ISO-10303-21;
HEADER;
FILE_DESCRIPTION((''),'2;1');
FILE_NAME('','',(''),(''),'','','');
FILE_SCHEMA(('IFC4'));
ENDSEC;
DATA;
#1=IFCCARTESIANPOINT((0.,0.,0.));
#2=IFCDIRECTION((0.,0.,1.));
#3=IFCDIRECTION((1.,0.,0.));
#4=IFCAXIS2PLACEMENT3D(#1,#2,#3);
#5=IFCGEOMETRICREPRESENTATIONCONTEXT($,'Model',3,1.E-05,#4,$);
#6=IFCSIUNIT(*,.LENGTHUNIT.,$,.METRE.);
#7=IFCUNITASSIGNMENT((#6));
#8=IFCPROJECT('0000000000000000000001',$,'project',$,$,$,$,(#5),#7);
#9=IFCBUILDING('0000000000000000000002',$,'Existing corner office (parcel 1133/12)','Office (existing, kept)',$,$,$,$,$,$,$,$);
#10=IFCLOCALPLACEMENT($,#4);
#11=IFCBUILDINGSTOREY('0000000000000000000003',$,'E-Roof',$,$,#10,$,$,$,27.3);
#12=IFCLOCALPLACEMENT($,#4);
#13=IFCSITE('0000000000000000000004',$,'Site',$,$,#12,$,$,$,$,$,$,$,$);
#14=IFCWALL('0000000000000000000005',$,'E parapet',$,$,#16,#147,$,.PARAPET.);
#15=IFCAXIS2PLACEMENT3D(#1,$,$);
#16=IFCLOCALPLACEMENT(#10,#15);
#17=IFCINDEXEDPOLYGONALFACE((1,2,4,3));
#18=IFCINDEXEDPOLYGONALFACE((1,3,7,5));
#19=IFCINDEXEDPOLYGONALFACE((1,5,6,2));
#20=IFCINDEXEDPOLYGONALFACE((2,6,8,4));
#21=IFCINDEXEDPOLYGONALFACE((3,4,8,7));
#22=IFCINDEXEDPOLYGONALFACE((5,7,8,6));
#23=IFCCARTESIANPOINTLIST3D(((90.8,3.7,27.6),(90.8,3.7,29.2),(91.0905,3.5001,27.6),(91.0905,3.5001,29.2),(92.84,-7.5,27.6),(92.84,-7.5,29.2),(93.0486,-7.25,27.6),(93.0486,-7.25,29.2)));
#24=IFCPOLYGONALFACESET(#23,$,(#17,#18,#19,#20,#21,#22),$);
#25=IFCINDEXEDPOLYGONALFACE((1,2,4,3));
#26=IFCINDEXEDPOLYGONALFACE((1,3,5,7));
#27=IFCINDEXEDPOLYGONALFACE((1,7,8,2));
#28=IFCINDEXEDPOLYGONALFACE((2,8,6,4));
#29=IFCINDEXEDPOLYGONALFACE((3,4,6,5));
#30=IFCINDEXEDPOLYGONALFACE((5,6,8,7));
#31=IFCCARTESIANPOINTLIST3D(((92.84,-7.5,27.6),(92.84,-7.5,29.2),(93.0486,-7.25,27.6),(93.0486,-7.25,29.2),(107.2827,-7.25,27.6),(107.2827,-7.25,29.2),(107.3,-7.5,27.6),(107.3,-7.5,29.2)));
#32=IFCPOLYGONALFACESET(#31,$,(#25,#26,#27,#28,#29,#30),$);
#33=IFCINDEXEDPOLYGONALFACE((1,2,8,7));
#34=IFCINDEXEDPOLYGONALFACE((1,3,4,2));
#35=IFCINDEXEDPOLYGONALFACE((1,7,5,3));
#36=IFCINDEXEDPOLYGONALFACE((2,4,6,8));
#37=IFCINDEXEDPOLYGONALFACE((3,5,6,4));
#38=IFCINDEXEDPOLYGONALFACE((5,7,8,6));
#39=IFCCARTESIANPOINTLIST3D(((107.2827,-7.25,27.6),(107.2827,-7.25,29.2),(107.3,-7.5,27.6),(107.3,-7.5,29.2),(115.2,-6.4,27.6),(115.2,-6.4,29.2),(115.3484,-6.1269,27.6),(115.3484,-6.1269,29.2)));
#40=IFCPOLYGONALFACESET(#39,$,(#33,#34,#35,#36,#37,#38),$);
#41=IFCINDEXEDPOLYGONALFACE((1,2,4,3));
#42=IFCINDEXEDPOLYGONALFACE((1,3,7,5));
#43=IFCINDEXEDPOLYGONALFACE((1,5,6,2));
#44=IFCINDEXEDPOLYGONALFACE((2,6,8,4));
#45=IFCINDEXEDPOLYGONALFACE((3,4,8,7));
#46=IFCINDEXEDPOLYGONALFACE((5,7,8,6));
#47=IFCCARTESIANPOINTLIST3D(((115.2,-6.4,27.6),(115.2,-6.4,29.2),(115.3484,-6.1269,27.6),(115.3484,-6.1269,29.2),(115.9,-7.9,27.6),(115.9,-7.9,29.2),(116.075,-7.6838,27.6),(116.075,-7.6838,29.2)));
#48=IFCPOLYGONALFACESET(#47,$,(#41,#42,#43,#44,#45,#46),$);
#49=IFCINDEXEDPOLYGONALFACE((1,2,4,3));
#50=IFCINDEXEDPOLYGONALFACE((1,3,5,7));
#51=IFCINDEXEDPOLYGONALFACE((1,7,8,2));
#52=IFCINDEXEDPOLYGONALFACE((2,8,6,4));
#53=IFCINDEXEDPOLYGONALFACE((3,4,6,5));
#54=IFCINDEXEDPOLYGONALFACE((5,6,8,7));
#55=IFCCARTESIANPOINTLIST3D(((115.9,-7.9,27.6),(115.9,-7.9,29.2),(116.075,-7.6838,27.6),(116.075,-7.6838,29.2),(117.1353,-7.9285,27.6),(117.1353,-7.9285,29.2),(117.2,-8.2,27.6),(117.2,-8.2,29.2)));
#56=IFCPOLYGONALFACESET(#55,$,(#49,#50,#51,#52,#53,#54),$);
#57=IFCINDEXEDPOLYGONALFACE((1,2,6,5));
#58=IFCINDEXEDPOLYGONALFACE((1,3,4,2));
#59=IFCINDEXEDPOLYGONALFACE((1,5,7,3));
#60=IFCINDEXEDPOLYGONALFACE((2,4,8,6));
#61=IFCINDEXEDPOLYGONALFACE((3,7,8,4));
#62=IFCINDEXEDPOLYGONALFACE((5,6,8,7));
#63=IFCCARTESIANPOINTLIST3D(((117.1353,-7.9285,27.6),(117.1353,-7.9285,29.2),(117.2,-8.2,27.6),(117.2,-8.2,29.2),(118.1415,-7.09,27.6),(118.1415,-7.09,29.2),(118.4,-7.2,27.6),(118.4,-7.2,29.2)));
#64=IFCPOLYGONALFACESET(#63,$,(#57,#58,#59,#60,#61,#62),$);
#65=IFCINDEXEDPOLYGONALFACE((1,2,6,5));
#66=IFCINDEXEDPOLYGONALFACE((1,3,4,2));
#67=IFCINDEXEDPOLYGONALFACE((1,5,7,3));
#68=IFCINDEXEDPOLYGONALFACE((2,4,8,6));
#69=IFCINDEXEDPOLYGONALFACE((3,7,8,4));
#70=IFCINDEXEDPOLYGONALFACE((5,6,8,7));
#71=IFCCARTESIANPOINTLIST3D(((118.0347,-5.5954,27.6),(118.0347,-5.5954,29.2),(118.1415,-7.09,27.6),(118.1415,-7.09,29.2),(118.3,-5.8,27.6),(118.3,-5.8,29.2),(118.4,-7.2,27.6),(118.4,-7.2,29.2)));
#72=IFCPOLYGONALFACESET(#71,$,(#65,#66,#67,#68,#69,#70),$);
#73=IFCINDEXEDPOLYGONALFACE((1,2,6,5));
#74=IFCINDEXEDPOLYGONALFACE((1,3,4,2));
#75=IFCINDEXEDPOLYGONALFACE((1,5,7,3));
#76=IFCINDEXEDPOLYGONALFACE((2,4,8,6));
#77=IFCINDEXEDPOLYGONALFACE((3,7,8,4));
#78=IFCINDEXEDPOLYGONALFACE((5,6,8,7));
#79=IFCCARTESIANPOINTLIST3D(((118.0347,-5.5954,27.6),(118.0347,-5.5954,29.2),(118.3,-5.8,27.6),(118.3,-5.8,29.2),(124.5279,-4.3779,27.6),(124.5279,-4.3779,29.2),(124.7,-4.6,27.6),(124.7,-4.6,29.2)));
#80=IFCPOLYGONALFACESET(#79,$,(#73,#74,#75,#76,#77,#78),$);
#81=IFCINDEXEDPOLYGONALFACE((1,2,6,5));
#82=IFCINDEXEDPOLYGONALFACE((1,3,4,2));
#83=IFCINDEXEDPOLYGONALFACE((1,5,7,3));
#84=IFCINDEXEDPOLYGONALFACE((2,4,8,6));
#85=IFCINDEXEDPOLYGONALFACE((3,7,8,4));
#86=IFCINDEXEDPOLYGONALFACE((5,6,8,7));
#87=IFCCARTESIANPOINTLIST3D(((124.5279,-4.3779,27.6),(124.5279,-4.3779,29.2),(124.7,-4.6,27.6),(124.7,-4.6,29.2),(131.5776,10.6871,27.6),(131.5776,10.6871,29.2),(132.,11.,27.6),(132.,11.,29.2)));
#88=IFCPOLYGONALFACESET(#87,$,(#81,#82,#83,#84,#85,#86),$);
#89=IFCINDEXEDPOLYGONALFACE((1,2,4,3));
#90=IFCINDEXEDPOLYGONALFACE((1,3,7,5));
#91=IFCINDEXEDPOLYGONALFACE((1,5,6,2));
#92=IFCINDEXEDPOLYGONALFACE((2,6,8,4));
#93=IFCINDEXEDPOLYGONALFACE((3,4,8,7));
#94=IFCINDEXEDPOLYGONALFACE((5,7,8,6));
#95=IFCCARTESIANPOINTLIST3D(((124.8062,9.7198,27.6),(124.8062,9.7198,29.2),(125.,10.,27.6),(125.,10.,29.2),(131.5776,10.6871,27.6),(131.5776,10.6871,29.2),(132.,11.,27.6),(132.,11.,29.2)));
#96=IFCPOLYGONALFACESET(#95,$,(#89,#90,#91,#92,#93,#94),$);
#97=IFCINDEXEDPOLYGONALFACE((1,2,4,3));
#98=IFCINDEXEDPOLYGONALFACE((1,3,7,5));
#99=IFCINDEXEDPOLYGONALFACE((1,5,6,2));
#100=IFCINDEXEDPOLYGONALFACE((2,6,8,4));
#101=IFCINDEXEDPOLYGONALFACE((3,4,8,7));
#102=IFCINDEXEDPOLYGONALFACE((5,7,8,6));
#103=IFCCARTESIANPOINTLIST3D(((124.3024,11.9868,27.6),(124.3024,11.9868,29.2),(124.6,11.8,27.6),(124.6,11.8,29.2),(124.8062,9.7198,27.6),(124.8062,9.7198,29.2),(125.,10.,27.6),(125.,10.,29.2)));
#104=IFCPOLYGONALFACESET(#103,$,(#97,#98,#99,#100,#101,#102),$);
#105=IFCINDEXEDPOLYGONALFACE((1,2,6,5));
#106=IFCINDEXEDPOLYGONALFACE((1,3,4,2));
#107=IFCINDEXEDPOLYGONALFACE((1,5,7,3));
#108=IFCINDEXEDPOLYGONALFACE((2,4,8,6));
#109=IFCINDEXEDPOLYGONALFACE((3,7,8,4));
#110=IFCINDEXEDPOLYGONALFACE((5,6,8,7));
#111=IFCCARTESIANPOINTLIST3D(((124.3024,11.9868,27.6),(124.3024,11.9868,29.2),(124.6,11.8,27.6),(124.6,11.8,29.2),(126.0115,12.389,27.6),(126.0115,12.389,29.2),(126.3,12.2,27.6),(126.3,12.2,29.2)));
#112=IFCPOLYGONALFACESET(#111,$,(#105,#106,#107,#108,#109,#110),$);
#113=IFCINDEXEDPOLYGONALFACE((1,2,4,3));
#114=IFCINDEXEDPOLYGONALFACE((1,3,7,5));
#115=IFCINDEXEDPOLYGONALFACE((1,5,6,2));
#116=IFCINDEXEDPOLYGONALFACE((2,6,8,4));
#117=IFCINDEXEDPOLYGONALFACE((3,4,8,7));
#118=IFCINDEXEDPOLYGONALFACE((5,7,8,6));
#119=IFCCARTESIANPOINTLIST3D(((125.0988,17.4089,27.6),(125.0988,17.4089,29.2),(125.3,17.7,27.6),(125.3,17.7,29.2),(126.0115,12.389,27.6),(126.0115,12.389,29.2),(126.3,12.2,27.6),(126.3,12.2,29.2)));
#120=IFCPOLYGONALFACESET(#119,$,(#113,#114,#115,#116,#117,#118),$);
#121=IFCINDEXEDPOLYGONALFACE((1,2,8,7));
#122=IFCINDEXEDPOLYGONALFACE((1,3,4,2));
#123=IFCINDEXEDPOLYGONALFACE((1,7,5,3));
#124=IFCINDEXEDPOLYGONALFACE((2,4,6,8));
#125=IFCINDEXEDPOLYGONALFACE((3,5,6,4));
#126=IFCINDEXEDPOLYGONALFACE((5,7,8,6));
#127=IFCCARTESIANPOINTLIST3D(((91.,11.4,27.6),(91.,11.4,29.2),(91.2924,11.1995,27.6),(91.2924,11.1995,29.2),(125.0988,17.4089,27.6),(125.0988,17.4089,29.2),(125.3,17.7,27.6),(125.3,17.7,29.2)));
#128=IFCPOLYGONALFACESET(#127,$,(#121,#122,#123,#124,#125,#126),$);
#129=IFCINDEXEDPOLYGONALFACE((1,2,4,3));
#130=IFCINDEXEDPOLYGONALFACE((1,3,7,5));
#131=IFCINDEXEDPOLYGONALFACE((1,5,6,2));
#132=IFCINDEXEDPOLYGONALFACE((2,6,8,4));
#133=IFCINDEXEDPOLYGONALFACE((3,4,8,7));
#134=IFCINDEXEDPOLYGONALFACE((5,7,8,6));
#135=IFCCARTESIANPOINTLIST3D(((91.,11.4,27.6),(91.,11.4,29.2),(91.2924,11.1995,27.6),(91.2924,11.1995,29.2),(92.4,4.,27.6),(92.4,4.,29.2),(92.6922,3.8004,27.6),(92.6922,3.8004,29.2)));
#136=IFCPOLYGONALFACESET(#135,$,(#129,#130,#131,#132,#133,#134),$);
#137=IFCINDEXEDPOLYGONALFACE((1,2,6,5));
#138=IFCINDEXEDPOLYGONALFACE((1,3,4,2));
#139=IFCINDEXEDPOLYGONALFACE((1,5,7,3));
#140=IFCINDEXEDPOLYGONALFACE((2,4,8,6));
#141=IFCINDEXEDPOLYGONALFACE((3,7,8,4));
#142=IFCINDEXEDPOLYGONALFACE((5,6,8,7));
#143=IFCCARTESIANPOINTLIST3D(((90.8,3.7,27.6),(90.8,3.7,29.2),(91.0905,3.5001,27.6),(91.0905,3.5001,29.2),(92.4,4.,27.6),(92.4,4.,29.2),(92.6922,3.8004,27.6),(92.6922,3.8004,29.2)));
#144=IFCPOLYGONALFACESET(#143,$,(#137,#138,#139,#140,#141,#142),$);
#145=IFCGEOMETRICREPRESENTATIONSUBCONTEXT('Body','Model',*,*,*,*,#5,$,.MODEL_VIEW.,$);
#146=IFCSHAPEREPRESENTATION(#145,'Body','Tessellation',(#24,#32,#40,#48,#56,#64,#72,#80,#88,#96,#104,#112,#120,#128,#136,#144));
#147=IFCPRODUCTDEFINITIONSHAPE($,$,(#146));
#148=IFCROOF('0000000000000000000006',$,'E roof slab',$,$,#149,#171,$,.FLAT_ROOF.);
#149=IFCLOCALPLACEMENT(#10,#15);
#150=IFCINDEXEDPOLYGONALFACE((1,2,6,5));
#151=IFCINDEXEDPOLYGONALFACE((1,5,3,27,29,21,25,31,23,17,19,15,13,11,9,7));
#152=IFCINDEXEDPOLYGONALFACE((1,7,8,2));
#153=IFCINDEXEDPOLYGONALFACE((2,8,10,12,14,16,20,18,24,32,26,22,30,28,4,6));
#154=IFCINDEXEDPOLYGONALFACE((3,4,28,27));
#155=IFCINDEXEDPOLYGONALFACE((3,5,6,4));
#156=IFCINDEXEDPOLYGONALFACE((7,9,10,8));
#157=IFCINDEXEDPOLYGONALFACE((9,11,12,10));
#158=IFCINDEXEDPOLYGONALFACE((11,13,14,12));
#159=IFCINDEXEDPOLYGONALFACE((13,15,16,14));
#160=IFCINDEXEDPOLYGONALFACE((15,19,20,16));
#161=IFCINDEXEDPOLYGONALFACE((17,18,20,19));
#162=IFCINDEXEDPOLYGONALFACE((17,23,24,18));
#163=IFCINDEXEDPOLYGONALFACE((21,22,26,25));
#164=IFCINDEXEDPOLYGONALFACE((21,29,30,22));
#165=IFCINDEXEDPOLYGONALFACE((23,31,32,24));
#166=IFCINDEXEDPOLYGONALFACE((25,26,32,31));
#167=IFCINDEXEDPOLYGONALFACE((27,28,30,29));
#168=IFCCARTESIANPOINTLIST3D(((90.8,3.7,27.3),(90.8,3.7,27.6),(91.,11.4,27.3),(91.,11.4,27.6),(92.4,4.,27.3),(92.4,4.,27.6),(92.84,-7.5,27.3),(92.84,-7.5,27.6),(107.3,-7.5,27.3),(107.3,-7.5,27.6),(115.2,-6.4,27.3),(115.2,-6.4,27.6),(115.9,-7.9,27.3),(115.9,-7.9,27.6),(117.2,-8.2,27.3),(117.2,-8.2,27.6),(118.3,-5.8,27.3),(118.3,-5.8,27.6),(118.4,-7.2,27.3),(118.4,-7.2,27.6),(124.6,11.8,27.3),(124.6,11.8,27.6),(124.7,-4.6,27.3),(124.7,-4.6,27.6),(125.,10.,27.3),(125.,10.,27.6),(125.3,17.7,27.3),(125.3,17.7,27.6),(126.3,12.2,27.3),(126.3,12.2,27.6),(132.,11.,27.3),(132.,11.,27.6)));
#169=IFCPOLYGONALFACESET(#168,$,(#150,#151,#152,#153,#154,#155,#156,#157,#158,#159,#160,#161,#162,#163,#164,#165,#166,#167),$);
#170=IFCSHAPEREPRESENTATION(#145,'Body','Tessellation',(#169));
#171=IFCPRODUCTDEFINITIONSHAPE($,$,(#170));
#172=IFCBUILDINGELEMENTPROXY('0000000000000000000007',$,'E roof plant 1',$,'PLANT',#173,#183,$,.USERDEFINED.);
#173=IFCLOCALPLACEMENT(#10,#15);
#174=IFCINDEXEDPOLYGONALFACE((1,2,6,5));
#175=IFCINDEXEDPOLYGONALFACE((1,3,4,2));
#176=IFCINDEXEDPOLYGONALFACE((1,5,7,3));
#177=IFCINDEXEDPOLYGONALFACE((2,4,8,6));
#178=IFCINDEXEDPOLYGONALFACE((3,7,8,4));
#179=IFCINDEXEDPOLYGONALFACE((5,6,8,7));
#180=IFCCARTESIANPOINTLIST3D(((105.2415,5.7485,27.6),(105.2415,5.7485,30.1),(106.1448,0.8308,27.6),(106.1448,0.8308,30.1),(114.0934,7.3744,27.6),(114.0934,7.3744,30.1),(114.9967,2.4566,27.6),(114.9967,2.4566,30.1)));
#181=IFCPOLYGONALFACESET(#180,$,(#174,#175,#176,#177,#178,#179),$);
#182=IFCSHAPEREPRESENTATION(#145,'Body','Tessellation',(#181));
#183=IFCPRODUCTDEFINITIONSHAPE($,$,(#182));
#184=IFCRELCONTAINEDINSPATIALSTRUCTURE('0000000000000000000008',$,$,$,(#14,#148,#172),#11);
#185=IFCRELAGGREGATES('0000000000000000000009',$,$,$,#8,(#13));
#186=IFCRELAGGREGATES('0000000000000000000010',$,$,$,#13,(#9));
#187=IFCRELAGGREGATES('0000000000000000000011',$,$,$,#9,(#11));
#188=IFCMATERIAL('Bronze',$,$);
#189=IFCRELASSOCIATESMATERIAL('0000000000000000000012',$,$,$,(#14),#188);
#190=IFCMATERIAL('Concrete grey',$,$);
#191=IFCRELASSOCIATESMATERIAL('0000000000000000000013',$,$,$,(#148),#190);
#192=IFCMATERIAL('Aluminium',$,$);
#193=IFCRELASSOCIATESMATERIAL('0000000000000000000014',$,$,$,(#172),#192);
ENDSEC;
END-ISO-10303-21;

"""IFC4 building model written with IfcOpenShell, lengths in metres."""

from ifc_helpers import new_model, si_unit, frame, origin_with_axes, place, context, subcontext, project, spatial, polyline, outline, extrude, material, element, save


model = new_model("IFC4")

# Units and contexts
model_context = context("Model", 3, precision=1e-05, world=origin_with_axes())
body_context = subcontext(model_context, "Body", "Model", "MODEL_VIEW")
ifc_project = project(units=[si_unit("LENGTHUNIT", "METRE")], contexts=[model_context])

# Site, building, storey
site_placement = place(None, origin_with_axes())
site = spatial("IfcSite", under=ifc_project, at=site_placement, Name="Site")
building = spatial("IfcBuilding", under=site, Name="Existing corner office (parcel 1133/12)", Description="Office (existing, kept)")
storey_placement = place(None, origin_with_axes())
storey = spatial("IfcBuildingStorey", under=building, at=storey_placement, Name="E-Roof", Elevation=27.3)

# Wall
ifc_material_1 = material(Name="Bronze")
wall_placement = place(storey_placement, origin_with_axes())
element("IfcWall", 1, at=wall_placement, inside=storey, material=ifc_material_1, Name="E parapet", PredefinedType="PARAPET", context=body_context, shape_type="SweptSolid", body=[
    extrude(outline(polyline([(90.8, 3.7), (92.84, -7.5), (93.0486, -7.25), (91.0905, 3.5001), (90.8, 3.7)])), frame((0.0, 0.0, 27.6), z_axis=(0.0, 0.0, 1.0), x_axis=(1.0, 0.0, 0.0)), (0.0, 0.0, 1.0), 1.6),
    extrude(outline(polyline([(92.84, -7.5), (107.3, -7.5), (107.2827, -7.25), (93.0486, -7.25), (92.84, -7.5)])), frame((0.0, 0.0, 27.6), z_axis=(0.0, 0.0, 1.0), x_axis=(1.0, 0.0, 0.0)), (0.0, 0.0, 1.0), 1.6),
    extrude(outline(polyline([(107.3, -7.5), (115.2, -6.4), (115.3484, -6.1269), (107.2827, -7.25), (107.3, -7.5)])), frame((0.0, 0.0, 27.6), z_axis=(0.0, 0.0, 1.0), x_axis=(1.0, 0.0, 0.0)), (0.0, 0.0, 1.0), 1.6),
    extrude(outline(polyline([(115.2, -6.4), (115.9, -7.9), (116.075, -7.6838), (115.3484, -6.1269), (115.2, -6.4)])), frame((0.0, 0.0, 27.6), z_axis=(0.0, 0.0, 1.0), x_axis=(1.0, 0.0, 0.0)), (0.0, 0.0, 1.0), 1.6),
    extrude(outline(polyline([(115.9, -7.9), (117.2, -8.2), (117.1353, -7.9285), (116.075, -7.6838), (115.9, -7.9)])), frame((0.0, 0.0, 27.6), z_axis=(0.0, 0.0, 1.0), x_axis=(1.0, 0.0, 0.0)), (0.0, 0.0, 1.0), 1.6),
    extrude(outline(polyline([(117.2, -8.2), (118.4, -7.2), (118.1415, -7.09), (117.1353, -7.9285), (117.2, -8.2)])), frame((0.0, 0.0, 27.6), z_axis=(0.0, 0.0, 1.0), x_axis=(1.0, 0.0, 0.0)), (0.0, 0.0, 1.0), 1.6),
    extrude(outline(polyline([(118.4, -7.2), (118.3, -5.8), (118.0347, -5.5954), (118.1415, -7.09), (118.4, -7.2)])), frame((0.0, 0.0, 27.6), z_axis=(0.0, 0.0, 1.0), x_axis=(1.0, 0.0, 0.0)), (0.0, 0.0, 1.0), 1.6),
    extrude(outline(polyline([(118.3, -5.8), (124.7, -4.6), (124.5279, -4.3779), (118.0347, -5.5954), (118.3, -5.8)])), frame((0.0, 0.0, 27.6), z_axis=(0.0, 0.0, 1.0), x_axis=(1.0, 0.0, 0.0)), (0.0, 0.0, 1.0), 1.6),
    extrude(outline(polyline([(124.7, -4.6), (132.0, 11.0), (131.5776, 10.6871), (124.5279, -4.3779), (124.7, -4.6)])), frame((0.0, 0.0, 27.6), z_axis=(0.0, 0.0, 1.0), x_axis=(1.0, 0.0, 0.0)), (0.0, 0.0, 1.0), 1.6),
    extrude(outline(polyline([(132.0, 11.0), (125.0, 10.0), (124.8062, 9.7198), (131.5776, 10.6871), (132.0, 11.0)])), frame((0.0, 0.0, 27.6), z_axis=(0.0, 0.0, 1.0), x_axis=(1.0, 0.0, 0.0)), (0.0, 0.0, 1.0), 1.6),
    extrude(outline(polyline([(125.0, 10.0), (124.6, 11.8), (124.3024, 11.9868), (124.8062, 9.7198), (125.0, 10.0)])), frame((0.0, 0.0, 27.6), z_axis=(0.0, 0.0, 1.0), x_axis=(1.0, 0.0, 0.0)), (0.0, 0.0, 1.0), 1.6),
    extrude(outline(polyline([(124.6, 11.8), (126.3, 12.2), (126.0115, 12.389), (124.3024, 11.9868), (124.6, 11.8)])), frame((0.0, 0.0, 27.6), z_axis=(0.0, 0.0, 1.0), x_axis=(1.0, 0.0, 0.0)), (0.0, 0.0, 1.0), 1.6),
    extrude(outline(polyline([(126.3, 12.2), (125.3, 17.7), (125.0988, 17.4089), (126.0115, 12.389), (126.3, 12.2)])), frame((0.0, 0.0, 27.6), z_axis=(0.0, 0.0, 1.0), x_axis=(1.0, 0.0, 0.0)), (0.0, 0.0, 1.0), 1.6),
    extrude(outline(polyline([(125.3, 17.7), (91.0, 11.4), (91.2924, 11.1995), (125.0988, 17.4089), (125.3, 17.7)])), frame((0.0, 0.0, 27.6), z_axis=(0.0, 0.0, 1.0), x_axis=(1.0, 0.0, 0.0)), (0.0, 0.0, 1.0), 1.6),
    extrude(outline(polyline([(91.0, 11.4), (92.4, 4.0), (92.6922, 3.8004), (91.2924, 11.1995), (91.0, 11.4)])), frame((0.0, 0.0, 27.6), z_axis=(0.0, 0.0, 1.0), x_axis=(1.0, 0.0, 0.0)), (0.0, 0.0, 1.0), 1.6),
    extrude(outline(polyline([(92.4, 4.0), (90.8, 3.7), (91.0905, 3.5001), (92.6922, 3.8004), (92.4, 4.0)])), frame((0.0, 0.0, 27.6), z_axis=(0.0, 0.0, 1.0), x_axis=(1.0, 0.0, 0.0)), (0.0, 0.0, 1.0), 1.6),
])

# Roof
ifc_material_2 = material(Name="Concrete grey")
roof_placement = place(storey_placement, origin_with_axes())
element("IfcRoof", 2, at=roof_placement, inside=storey, material=ifc_material_2, Name="E roof slab", PredefinedType="FLAT_ROOF", context=body_context, shape_type="SweptSolid", body=[
    extrude(outline(polyline([(90.8, 3.7), (92.84, -7.5), (107.3, -7.5), (115.2, -6.4), (115.9, -7.9), (117.2, -8.2), (118.4, -7.2), (118.3, -5.8), (124.7, -4.6), (132.0, 11.0), (125.0, 10.0), (124.6, 11.8), (126.3, 12.2), (125.3, 17.7), (91.0, 11.4), (92.4, 4.0), (90.8, 3.7)])), frame((0.0, 0.0, 27.3), z_axis=(0.0, 0.0, 1.0), x_axis=(1.0, 0.0, 0.0)), (0.0, 0.0, 1.0), 0.3),
])

# Building element proxy
ifc_material_3 = material(Name="Aluminium")
proxy_placement = place(storey_placement, origin_with_axes())
element("IfcBuildingElementProxy", 3, at=proxy_placement, inside=storey, material=ifc_material_3, Name="E roof plant 1", ObjectType="PLANT", PredefinedType="USERDEFINED", context=body_context, shape_type="SweptSolid", body=[
    extrude(outline(polyline([(114.0934, 7.3744), (105.2415, 5.7485), (106.1448, 0.8308), (114.9967, 2.4566), (114.0934, 7.3744)])), frame((0.0, 0.0, 27.6), z_axis=(0.0, 0.0, 1.0), x_axis=(1.0, 0.0, 0.0)), (0.0, 0.0, 1.0), 2.5),
])

save(model, "model.ifc")
